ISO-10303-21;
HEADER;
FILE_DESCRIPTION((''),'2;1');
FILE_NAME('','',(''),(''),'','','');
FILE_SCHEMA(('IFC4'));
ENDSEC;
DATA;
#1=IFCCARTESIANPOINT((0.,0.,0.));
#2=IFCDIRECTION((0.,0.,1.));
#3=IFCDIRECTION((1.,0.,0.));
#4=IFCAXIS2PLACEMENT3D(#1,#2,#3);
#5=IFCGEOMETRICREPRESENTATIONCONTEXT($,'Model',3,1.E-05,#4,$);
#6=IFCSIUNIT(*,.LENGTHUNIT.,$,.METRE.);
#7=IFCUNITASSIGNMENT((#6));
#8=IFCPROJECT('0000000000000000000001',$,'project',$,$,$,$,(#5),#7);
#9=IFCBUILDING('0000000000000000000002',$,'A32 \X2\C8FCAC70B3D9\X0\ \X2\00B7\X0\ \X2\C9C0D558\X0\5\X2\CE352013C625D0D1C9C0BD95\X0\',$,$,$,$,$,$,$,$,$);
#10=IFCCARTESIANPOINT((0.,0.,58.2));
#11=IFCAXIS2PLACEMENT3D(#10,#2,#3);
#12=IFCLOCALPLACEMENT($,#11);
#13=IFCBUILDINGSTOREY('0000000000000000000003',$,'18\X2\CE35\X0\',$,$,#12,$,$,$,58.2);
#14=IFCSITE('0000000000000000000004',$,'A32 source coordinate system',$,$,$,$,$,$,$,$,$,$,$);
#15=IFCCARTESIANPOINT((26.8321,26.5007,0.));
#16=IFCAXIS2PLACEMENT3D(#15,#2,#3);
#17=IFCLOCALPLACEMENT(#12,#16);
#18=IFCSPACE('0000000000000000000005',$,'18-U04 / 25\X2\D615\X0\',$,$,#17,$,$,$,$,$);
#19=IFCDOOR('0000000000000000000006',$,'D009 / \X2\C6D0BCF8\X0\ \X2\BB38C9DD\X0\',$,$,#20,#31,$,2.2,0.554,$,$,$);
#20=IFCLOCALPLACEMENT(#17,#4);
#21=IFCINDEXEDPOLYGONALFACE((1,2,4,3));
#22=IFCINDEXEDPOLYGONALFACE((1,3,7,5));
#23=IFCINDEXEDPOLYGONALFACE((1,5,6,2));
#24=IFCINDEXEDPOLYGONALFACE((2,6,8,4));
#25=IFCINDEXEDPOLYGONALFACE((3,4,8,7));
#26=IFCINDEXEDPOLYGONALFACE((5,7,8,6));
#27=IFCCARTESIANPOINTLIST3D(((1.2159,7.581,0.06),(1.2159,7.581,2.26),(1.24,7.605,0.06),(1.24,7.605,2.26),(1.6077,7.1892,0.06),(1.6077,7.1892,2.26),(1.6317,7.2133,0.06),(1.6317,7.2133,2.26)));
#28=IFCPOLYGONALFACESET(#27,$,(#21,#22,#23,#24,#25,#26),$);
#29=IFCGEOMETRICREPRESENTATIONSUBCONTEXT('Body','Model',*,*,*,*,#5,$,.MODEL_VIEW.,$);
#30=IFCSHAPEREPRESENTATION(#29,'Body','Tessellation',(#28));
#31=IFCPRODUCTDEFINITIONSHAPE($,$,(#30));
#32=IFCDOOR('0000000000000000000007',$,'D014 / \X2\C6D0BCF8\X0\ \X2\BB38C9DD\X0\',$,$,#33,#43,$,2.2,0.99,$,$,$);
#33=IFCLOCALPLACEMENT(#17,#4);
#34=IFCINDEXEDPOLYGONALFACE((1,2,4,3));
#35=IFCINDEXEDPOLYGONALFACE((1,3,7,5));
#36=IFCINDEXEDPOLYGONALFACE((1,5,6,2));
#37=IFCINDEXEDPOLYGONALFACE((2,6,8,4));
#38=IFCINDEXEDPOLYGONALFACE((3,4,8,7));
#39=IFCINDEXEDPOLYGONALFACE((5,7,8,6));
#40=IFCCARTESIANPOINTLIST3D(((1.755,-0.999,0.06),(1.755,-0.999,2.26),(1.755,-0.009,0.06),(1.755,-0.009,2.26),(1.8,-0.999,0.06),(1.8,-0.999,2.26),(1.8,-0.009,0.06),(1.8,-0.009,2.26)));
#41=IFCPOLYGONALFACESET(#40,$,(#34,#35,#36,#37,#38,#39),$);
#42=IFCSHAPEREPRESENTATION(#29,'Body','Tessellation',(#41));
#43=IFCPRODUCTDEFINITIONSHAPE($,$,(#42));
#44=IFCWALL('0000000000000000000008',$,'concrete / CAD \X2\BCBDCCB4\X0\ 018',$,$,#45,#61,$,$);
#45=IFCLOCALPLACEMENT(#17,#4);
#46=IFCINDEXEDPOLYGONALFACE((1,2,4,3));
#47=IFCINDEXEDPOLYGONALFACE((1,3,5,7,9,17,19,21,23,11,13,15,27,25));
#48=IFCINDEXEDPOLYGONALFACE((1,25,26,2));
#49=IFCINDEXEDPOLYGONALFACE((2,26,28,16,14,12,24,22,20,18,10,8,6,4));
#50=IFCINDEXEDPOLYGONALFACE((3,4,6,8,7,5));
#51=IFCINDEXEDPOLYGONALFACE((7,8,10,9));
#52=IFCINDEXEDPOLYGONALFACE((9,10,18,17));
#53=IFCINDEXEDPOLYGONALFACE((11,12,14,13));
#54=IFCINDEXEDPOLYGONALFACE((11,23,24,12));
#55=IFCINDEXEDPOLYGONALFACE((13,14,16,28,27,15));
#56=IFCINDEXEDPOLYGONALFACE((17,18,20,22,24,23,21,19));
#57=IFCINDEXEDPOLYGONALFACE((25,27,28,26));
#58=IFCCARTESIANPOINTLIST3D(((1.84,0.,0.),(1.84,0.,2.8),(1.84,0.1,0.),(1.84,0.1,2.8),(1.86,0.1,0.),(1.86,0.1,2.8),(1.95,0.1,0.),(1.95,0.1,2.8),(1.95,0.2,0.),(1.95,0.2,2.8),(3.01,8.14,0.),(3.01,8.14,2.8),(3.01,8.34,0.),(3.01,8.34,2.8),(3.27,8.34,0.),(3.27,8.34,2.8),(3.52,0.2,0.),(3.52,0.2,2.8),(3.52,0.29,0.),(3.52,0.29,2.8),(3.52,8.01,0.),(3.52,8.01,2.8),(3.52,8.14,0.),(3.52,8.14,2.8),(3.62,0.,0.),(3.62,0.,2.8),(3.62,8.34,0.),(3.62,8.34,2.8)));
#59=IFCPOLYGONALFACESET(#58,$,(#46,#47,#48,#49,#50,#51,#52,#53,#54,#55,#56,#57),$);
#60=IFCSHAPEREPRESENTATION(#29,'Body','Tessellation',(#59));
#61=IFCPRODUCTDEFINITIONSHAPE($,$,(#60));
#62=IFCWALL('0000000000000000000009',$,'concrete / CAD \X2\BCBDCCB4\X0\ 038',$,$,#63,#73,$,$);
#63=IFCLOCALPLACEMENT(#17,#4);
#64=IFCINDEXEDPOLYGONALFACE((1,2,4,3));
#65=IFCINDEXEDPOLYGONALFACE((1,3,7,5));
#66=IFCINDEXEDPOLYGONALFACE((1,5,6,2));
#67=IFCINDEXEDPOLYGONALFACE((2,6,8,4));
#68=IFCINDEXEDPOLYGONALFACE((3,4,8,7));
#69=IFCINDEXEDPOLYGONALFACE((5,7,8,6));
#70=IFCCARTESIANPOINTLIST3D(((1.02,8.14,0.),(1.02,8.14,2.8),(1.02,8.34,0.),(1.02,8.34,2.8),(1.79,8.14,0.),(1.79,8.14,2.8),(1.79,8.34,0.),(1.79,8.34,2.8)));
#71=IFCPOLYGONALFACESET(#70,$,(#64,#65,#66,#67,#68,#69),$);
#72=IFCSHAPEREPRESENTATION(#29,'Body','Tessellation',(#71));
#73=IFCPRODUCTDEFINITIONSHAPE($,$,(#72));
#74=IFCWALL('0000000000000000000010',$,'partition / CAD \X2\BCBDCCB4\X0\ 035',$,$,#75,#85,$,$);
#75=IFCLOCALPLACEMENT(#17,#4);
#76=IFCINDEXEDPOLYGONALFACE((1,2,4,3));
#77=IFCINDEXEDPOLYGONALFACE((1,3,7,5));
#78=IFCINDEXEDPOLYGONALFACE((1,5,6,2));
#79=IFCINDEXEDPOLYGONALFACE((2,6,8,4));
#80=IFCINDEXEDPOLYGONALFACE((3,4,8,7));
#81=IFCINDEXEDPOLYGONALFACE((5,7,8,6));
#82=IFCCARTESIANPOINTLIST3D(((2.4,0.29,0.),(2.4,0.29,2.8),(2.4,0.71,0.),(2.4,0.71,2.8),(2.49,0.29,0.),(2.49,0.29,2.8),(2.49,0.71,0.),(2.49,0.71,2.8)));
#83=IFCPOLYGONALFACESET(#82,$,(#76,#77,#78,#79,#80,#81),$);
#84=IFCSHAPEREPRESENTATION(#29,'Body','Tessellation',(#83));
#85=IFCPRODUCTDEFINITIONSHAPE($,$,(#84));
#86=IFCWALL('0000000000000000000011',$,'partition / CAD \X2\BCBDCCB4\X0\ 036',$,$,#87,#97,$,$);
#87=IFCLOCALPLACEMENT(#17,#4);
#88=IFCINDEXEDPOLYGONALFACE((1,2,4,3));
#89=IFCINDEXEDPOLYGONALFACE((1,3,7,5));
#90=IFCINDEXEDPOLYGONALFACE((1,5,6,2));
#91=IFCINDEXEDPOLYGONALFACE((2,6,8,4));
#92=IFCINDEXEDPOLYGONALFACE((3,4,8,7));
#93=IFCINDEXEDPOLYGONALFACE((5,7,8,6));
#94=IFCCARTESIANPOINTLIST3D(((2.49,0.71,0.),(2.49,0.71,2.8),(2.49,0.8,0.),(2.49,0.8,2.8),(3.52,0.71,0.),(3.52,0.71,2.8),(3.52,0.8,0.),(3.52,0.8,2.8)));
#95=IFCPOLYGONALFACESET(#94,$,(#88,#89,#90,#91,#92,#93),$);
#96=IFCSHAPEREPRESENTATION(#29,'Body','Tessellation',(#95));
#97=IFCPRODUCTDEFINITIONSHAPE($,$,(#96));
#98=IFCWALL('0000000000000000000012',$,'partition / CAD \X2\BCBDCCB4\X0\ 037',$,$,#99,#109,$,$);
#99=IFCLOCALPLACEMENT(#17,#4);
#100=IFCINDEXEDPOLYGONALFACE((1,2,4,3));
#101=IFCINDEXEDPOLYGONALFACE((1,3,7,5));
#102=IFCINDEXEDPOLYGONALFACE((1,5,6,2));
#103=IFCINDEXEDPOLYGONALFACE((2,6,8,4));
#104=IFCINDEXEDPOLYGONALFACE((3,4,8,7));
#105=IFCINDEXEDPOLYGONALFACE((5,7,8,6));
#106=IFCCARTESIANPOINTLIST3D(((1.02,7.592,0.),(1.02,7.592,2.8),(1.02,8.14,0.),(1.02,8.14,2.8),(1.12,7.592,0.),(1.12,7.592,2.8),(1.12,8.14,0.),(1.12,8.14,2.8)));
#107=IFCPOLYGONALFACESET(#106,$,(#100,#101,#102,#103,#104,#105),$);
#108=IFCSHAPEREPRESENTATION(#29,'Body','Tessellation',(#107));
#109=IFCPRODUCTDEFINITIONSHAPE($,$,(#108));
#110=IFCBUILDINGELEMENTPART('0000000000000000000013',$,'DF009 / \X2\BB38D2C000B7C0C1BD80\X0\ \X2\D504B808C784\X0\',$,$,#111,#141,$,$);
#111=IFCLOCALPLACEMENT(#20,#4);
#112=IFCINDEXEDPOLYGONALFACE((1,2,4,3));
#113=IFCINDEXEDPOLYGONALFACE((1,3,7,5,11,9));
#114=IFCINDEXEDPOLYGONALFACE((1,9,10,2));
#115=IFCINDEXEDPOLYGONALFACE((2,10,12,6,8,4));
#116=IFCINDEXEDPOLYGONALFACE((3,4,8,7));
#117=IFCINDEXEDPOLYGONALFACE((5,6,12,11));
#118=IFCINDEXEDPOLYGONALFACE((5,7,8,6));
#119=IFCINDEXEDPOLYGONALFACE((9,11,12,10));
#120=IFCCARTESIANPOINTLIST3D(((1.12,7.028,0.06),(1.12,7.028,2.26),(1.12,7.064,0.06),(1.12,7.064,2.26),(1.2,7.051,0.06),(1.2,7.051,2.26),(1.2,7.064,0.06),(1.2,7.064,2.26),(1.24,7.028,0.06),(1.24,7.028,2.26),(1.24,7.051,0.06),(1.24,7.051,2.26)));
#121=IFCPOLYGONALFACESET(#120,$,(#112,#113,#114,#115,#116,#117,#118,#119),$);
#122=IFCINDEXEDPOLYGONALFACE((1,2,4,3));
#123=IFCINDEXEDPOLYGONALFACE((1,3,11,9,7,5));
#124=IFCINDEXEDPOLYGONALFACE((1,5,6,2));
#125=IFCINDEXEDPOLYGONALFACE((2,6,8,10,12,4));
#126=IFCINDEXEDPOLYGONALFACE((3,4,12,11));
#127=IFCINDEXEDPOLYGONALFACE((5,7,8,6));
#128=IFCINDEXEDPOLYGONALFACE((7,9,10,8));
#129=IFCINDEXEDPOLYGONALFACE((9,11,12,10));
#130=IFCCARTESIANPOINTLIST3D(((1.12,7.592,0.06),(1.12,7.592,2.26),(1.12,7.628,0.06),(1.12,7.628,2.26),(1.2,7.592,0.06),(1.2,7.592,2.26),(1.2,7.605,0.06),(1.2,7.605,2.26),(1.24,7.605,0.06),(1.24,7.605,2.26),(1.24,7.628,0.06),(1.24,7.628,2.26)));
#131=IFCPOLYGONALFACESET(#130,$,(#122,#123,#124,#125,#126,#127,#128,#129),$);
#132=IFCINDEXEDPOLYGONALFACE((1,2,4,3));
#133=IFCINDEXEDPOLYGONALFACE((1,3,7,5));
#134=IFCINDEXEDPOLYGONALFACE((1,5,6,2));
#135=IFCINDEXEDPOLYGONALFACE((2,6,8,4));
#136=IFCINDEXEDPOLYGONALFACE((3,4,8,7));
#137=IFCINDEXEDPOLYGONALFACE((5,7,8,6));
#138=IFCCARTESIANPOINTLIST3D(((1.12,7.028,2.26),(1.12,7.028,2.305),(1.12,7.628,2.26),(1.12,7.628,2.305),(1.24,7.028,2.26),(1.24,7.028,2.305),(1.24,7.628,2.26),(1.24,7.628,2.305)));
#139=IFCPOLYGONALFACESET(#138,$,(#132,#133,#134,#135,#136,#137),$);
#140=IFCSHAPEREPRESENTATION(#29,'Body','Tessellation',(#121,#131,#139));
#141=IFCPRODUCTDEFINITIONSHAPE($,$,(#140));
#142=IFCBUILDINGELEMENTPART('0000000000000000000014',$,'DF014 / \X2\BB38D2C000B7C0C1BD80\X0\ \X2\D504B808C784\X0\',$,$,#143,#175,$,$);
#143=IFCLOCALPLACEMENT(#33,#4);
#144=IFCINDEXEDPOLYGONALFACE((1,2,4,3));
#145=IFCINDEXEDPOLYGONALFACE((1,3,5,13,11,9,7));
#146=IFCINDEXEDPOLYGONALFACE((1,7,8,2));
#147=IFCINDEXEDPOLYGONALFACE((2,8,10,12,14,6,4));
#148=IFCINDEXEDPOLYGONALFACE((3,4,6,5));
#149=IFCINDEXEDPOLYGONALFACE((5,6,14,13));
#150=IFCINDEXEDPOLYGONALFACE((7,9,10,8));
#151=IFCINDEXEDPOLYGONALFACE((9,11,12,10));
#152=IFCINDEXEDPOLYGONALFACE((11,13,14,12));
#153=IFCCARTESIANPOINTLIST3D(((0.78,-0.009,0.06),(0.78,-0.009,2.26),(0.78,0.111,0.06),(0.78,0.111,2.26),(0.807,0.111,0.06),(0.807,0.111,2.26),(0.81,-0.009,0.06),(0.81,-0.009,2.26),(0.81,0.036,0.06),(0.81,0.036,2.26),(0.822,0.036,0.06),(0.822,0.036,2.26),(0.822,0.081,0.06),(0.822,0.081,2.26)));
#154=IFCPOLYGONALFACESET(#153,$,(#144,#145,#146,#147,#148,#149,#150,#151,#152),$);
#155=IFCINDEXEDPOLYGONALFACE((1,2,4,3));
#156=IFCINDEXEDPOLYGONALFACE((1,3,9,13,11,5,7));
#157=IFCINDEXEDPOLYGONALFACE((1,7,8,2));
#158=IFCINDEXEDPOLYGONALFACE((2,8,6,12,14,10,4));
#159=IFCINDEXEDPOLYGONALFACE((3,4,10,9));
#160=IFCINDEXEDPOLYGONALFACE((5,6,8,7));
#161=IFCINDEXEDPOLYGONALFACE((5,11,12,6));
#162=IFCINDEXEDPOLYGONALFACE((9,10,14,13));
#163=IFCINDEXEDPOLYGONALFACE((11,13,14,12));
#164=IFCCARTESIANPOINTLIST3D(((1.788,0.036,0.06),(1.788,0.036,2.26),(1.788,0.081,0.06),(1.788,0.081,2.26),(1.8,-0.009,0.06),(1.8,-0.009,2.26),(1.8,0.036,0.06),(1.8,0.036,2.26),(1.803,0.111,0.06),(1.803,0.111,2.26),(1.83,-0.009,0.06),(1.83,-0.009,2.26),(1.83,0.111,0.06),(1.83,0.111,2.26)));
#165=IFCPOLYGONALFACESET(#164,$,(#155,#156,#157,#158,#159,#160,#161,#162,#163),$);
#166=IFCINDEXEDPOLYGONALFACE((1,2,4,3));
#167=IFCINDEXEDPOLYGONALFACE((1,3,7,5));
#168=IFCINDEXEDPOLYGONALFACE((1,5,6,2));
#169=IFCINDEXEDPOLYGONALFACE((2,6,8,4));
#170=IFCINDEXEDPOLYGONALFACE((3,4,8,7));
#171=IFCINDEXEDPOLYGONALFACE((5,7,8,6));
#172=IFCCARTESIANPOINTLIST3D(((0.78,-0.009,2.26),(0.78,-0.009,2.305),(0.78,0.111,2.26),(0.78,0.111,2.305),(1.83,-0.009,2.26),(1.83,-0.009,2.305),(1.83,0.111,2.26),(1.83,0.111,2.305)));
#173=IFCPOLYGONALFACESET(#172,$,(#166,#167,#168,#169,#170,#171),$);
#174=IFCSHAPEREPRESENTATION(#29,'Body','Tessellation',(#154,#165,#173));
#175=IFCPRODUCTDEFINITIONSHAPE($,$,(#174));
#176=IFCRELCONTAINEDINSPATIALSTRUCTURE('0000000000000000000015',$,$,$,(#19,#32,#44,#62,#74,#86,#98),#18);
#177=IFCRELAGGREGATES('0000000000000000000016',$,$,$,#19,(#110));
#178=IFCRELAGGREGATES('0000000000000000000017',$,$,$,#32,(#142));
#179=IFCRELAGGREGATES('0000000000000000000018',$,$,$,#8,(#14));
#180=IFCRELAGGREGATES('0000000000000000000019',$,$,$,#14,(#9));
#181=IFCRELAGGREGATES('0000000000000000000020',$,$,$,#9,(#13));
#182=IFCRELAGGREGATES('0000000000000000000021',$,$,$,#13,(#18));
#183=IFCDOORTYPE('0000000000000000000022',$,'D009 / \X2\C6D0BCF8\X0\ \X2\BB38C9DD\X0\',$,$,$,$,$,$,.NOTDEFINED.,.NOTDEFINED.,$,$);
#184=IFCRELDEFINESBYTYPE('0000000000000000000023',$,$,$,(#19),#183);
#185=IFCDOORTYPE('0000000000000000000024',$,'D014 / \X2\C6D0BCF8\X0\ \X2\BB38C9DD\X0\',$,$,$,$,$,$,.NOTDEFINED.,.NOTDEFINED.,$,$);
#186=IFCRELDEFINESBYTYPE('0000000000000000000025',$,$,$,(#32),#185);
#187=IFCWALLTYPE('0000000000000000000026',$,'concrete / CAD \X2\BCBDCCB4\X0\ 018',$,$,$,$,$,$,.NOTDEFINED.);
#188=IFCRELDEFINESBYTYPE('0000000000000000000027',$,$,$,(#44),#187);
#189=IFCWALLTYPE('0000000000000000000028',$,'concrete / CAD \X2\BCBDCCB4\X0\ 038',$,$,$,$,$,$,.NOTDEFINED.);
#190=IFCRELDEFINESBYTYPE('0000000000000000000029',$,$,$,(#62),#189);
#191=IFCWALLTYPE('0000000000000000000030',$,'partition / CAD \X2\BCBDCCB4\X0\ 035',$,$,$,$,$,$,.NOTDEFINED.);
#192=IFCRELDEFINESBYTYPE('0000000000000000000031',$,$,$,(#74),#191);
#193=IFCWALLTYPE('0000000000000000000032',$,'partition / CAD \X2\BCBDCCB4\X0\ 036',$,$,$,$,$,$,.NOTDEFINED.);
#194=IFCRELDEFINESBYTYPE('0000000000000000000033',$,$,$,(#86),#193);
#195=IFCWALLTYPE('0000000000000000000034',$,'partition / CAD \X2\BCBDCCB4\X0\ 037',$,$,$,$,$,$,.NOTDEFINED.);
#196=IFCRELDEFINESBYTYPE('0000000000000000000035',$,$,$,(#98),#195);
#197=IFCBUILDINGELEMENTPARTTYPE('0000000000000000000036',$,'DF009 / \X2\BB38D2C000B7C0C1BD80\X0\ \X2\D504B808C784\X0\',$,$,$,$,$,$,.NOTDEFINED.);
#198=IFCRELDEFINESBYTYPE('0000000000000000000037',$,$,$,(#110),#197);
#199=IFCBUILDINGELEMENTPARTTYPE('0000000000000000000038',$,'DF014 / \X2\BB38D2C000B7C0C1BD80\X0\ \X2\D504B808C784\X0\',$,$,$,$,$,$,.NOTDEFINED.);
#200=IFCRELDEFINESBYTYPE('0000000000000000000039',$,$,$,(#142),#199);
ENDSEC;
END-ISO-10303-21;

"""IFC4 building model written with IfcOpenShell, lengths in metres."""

from ifc_helpers import new_model, si_unit, frame, origin, origin_with_axes, place, context, subcontext, project, spatial, polyline, outline, extrude, source, transform, mapped, type_object, type_shapes, element, aggregate, save


model = new_model("IFC4")

# Units and contexts
model_context = context("Model", 3, precision=1e-05, world=origin_with_axes())
body_context = subcontext(model_context, "Body", "Model", "MODEL_VIEW")
ifc_project = project(units=[si_unit("LENGTHUNIT", "METRE")], contexts=[model_context])

# Site, building, storey, space
storey_placement = place(None, frame((0.0, 0.0, 58.2), z_axis=(0.0, 0.0, 1.0), x_axis=(1.0, 0.0, 0.0)))
space_placement = place(storey_placement, frame((26.8321, 26.5007, 0.0), z_axis=(0.0, 0.0, 1.0), x_axis=(1.0, 0.0, 0.0)))
site = spatial("IfcSite", under=ifc_project, Name="A32 source coordinate system")
building = spatial("IfcBuilding", under=site, Name="A32 주거동 · 지하5층–옥탑지붕")
storey = spatial("IfcBuildingStorey", under=building, at=storey_placement, Name="18층", Elevation=58.2)
space = spatial("IfcSpace", under=storey, at=space_placement, Name="18-U04 / 25형")

# Doors
door_type_1 = type_object("IfcDoorType", Name="D009 / 원본 문짝", OperationType="NOTDEFINED", PredefinedType="NOTDEFINED")
shared_shape_1 = source(origin(), body_context, "Body", "SweptSolid", [
    extrude(outline(polyline([(1.24, 7.605), (1.6317, 7.2133), (1.6077, 7.1892), (1.2159, 7.581), (1.24, 7.605)])), frame((0.0, 0.0, 0.06)), (0.0, 0.0, 1.0), 2.2),
])
type_shapes(door_type_1, [shared_shape_1])
door_1_placement = place(space_placement, origin_with_axes())
door_1 = element("IfcDoor", 1, at=door_1_placement, inside=space, type_object=door_type_1, Name="D009 / 원본 문짝", OverallHeight=2.2, OverallWidth=0.554, context=body_context, shape_type="MappedRepresentation", body=[
    mapped(shared_shape_1, transform((0.0, 0.0, 0.0), scale=1.0)),
])
door_type_2 = type_object("IfcDoorType", Name="D014 / 원본 문짝", OperationType="NOTDEFINED", PredefinedType="NOTDEFINED")
shared_shape_2 = source(origin(), body_context, "Body", "SweptSolid", [
    extrude(outline(polyline([(1.8, -0.009), (1.8, -0.999), (1.755, -0.999), (1.755, -0.009), (1.8, -0.009)])), frame((0.0, 0.0, 0.06)), (0.0, 0.0, 1.0), 2.2),
])
type_shapes(door_type_2, [shared_shape_2])
door_2_placement = place(space_placement, origin_with_axes())
door_2 = element("IfcDoor", 2, at=door_2_placement, inside=space, type_object=door_type_2, Name="D014 / 원본 문짝", OverallHeight=2.2, OverallWidth=0.99, context=body_context, shape_type="MappedRepresentation", body=[
    mapped(shared_shape_2, transform((0.0, 0.0, 0.0), scale=1.0)),
])

# Walls
wall_type_1 = type_object("IfcWallType", Name="concrete / CAD 벽체 018", PredefinedType="NOTDEFINED")
shared_shape_3 = source(origin(), body_context, "Body", "SweptSolid", [
    extrude(outline(polyline([(3.27, 8.34), (3.27, 8.34), (3.62, 8.34), (3.62, 0.0), (1.84, 0.0), (1.84, 0.1), (1.86, 0.1), (1.95, 0.1), (1.95, 0.2), (3.52, 0.2), (3.52, 0.29), (3.52, 8.01), (3.52, 8.14), (3.01, 8.14), (3.01, 8.34), (3.27, 8.34)])), origin(), (0.0, 0.0, 1.0), 2.8),
])
type_shapes(wall_type_1, [shared_shape_3])
wall_1_placement = place(space_placement, origin_with_axes())
element("IfcWall", 3, at=wall_1_placement, inside=space, type_object=wall_type_1, Name="concrete / CAD 벽체 018", context=body_context, shape_type="MappedRepresentation", body=[
    mapped(shared_shape_3, transform((0.0, 0.0, 0.0), scale=1.0)),
])
wall_type_2 = type_object("IfcWallType", Name="concrete / CAD 벽체 038", PredefinedType="NOTDEFINED")
shared_shape_4 = source(origin(), body_context, "Body", "SweptSolid", [
    extrude(outline(polyline([(1.02, 8.14), (1.02, 8.34), (1.79, 8.34), (1.79, 8.14), (1.02, 8.14)])), origin(), (0.0, 0.0, 1.0), 2.8),
])
type_shapes(wall_type_2, [shared_shape_4])
wall_2_placement = place(space_placement, origin_with_axes())
element("IfcWall", 4, at=wall_2_placement, inside=space, type_object=wall_type_2, Name="concrete / CAD 벽체 038", context=body_context, shape_type="MappedRepresentation", body=[
    mapped(shared_shape_4, transform((0.0, 0.0, 0.0), scale=1.0)),
])
wall_type_3 = type_object("IfcWallType", Name="partition / CAD 벽체 035", PredefinedType="NOTDEFINED")
shared_shape_5 = source(origin(), body_context, "Body", "SweptSolid", [
    extrude(outline(polyline([(2.49, 0.71), (2.49, 0.29), (2.4, 0.29), (2.4, 0.71), (2.49, 0.71)])), origin(), (0.0, 0.0, 1.0), 2.8),
])
type_shapes(wall_type_3, [shared_shape_5])
wall_3_placement = place(space_placement, origin_with_axes())
element("IfcWall", 5, at=wall_3_placement, inside=space, type_object=wall_type_3, Name="partition / CAD 벽체 035", context=body_context, shape_type="MappedRepresentation", body=[
    mapped(shared_shape_5, transform((0.0, 0.0, 0.0), scale=1.0)),
])
wall_type_4 = type_object("IfcWallType", Name="partition / CAD 벽체 036", PredefinedType="NOTDEFINED")
shared_shape_6 = source(origin(), body_context, "Body", "SweptSolid", [
    extrude(outline(polyline([(2.49, 0.8), (3.52, 0.8), (3.52, 0.71), (2.49, 0.71), (2.49, 0.8)])), origin(), (0.0, 0.0, 1.0), 2.8),
])
type_shapes(wall_type_4, [shared_shape_6])
wall_4_placement = place(space_placement, origin_with_axes())
element("IfcWall", 6, at=wall_4_placement, inside=space, type_object=wall_type_4, Name="partition / CAD 벽체 036", context=body_context, shape_type="MappedRepresentation", body=[
    mapped(shared_shape_6, transform((0.0, 0.0, 0.0), scale=1.0)),
])
wall_type_5 = type_object("IfcWallType", Name="partition / CAD 벽체 037", PredefinedType="NOTDEFINED")
shared_shape_7 = source(origin(), body_context, "Body", "SweptSolid", [
    extrude(outline(polyline([(1.02, 7.592), (1.02, 8.14), (1.12, 8.14), (1.12, 7.592), (1.02, 7.592)])), origin(), (0.0, 0.0, 1.0), 2.8),
])
type_shapes(wall_type_5, [shared_shape_7])
wall_5_placement = place(space_placement, origin_with_axes())
element("IfcWall", 7, at=wall_5_placement, inside=space, type_object=wall_type_5, Name="partition / CAD 벽체 037", context=body_context, shape_type="MappedRepresentation", body=[
    mapped(shared_shape_7, transform((0.0, 0.0, 0.0), scale=1.0)),
])

# Building element parts
building_element_part_type_1 = type_object("IfcBuildingElementPartType", Name="DF009 / 문틀·상부 프레임", PredefinedType="NOTDEFINED")
shared_shape_8 = source(origin(), body_context, "Body", "SweptSolid", [
    extrude(outline(polyline([(1.12, 7.064), (1.2, 7.064), (1.2, 7.051), (1.24, 7.051), (1.24, 7.028), (1.12, 7.028), (1.12, 7.064)])), frame((0.0, 0.0, 0.06)), (0.0, 0.0, 1.0), 2.2),
    extrude(outline(polyline([(1.24, 7.628), (1.24, 7.605), (1.2, 7.605), (1.2, 7.592), (1.12, 7.592), (1.12, 7.628), (1.24, 7.628)])), frame((0.0, 0.0, 0.06)), (0.0, 0.0, 1.0), 2.2),
    extrude(outline(polyline([(1.12, 7.028), (1.12, 7.628), (1.24, 7.628), (1.24, 7.028), (1.12, 7.028)])), frame((0.0, 0.0, 2.26)), (0.0, 0.0, 1.0), 0.045),
])
type_shapes(building_element_part_type_1, [shared_shape_8])
building_element_part_1_placement = place(door_1_placement, origin_with_axes())
building_element_part_1 = element("IfcBuildingElementPart", 8, at=building_element_part_1_placement, type_object=building_element_part_type_1, Name="DF009 / 문틀·상부 프레임", context=body_context, shape_type="MappedRepresentation", body=[
    mapped(shared_shape_8, transform((0.0, 0.0, 0.0), scale=1.0)),
])
aggregate(door_1, [building_element_part_1])
building_element_part_type_2 = type_object("IfcBuildingElementPartType", Name="DF014 / 문틀·상부 프레임", PredefinedType="NOTDEFINED")
shared_shape_9 = source(origin(), body_context, "Body", "SweptSolid", [
    extrude(outline(polyline([(0.78, 0.111), (0.807, 0.111), (0.822, 0.081), (0.822, 0.036), (0.81, 0.036), (0.81, -0.009), (0.78, -0.009), (0.78, 0.111)])), frame((0.0, 0.0, 0.06)), (0.0, 0.0, 1.0), 2.2),
    extrude(outline(polyline([(1.8, -0.009), (1.8, 0.036), (1.788, 0.036), (1.788, 0.081), (1.803, 0.111), (1.83, 0.111), (1.83, -0.009), (1.8, -0.009)])), frame((0.0, 0.0, 0.06)), (0.0, 0.0, 1.0), 2.2),
    extrude(outline(polyline([(0.78, -0.009), (0.78, 0.111), (1.83, 0.111), (1.83, -0.009), (0.78, -0.009)])), frame((0.0, 0.0, 2.26)), (0.0, 0.0, 1.0), 0.045),
])
type_shapes(building_element_part_type_2, [shared_shape_9])
building_element_part_2_placement = place(door_2_placement, origin_with_axes())
building_element_part_2 = element("IfcBuildingElementPart", 9, at=building_element_part_2_placement, type_object=building_element_part_type_2, Name="DF014 / 문틀·상부 프레임", context=body_context, shape_type="MappedRepresentation", body=[
    mapped(shared_shape_9, transform((0.0, 0.0, 0.0), scale=1.0)),
])
aggregate(door_2, [building_element_part_2])

save(model, "model.ifc")
